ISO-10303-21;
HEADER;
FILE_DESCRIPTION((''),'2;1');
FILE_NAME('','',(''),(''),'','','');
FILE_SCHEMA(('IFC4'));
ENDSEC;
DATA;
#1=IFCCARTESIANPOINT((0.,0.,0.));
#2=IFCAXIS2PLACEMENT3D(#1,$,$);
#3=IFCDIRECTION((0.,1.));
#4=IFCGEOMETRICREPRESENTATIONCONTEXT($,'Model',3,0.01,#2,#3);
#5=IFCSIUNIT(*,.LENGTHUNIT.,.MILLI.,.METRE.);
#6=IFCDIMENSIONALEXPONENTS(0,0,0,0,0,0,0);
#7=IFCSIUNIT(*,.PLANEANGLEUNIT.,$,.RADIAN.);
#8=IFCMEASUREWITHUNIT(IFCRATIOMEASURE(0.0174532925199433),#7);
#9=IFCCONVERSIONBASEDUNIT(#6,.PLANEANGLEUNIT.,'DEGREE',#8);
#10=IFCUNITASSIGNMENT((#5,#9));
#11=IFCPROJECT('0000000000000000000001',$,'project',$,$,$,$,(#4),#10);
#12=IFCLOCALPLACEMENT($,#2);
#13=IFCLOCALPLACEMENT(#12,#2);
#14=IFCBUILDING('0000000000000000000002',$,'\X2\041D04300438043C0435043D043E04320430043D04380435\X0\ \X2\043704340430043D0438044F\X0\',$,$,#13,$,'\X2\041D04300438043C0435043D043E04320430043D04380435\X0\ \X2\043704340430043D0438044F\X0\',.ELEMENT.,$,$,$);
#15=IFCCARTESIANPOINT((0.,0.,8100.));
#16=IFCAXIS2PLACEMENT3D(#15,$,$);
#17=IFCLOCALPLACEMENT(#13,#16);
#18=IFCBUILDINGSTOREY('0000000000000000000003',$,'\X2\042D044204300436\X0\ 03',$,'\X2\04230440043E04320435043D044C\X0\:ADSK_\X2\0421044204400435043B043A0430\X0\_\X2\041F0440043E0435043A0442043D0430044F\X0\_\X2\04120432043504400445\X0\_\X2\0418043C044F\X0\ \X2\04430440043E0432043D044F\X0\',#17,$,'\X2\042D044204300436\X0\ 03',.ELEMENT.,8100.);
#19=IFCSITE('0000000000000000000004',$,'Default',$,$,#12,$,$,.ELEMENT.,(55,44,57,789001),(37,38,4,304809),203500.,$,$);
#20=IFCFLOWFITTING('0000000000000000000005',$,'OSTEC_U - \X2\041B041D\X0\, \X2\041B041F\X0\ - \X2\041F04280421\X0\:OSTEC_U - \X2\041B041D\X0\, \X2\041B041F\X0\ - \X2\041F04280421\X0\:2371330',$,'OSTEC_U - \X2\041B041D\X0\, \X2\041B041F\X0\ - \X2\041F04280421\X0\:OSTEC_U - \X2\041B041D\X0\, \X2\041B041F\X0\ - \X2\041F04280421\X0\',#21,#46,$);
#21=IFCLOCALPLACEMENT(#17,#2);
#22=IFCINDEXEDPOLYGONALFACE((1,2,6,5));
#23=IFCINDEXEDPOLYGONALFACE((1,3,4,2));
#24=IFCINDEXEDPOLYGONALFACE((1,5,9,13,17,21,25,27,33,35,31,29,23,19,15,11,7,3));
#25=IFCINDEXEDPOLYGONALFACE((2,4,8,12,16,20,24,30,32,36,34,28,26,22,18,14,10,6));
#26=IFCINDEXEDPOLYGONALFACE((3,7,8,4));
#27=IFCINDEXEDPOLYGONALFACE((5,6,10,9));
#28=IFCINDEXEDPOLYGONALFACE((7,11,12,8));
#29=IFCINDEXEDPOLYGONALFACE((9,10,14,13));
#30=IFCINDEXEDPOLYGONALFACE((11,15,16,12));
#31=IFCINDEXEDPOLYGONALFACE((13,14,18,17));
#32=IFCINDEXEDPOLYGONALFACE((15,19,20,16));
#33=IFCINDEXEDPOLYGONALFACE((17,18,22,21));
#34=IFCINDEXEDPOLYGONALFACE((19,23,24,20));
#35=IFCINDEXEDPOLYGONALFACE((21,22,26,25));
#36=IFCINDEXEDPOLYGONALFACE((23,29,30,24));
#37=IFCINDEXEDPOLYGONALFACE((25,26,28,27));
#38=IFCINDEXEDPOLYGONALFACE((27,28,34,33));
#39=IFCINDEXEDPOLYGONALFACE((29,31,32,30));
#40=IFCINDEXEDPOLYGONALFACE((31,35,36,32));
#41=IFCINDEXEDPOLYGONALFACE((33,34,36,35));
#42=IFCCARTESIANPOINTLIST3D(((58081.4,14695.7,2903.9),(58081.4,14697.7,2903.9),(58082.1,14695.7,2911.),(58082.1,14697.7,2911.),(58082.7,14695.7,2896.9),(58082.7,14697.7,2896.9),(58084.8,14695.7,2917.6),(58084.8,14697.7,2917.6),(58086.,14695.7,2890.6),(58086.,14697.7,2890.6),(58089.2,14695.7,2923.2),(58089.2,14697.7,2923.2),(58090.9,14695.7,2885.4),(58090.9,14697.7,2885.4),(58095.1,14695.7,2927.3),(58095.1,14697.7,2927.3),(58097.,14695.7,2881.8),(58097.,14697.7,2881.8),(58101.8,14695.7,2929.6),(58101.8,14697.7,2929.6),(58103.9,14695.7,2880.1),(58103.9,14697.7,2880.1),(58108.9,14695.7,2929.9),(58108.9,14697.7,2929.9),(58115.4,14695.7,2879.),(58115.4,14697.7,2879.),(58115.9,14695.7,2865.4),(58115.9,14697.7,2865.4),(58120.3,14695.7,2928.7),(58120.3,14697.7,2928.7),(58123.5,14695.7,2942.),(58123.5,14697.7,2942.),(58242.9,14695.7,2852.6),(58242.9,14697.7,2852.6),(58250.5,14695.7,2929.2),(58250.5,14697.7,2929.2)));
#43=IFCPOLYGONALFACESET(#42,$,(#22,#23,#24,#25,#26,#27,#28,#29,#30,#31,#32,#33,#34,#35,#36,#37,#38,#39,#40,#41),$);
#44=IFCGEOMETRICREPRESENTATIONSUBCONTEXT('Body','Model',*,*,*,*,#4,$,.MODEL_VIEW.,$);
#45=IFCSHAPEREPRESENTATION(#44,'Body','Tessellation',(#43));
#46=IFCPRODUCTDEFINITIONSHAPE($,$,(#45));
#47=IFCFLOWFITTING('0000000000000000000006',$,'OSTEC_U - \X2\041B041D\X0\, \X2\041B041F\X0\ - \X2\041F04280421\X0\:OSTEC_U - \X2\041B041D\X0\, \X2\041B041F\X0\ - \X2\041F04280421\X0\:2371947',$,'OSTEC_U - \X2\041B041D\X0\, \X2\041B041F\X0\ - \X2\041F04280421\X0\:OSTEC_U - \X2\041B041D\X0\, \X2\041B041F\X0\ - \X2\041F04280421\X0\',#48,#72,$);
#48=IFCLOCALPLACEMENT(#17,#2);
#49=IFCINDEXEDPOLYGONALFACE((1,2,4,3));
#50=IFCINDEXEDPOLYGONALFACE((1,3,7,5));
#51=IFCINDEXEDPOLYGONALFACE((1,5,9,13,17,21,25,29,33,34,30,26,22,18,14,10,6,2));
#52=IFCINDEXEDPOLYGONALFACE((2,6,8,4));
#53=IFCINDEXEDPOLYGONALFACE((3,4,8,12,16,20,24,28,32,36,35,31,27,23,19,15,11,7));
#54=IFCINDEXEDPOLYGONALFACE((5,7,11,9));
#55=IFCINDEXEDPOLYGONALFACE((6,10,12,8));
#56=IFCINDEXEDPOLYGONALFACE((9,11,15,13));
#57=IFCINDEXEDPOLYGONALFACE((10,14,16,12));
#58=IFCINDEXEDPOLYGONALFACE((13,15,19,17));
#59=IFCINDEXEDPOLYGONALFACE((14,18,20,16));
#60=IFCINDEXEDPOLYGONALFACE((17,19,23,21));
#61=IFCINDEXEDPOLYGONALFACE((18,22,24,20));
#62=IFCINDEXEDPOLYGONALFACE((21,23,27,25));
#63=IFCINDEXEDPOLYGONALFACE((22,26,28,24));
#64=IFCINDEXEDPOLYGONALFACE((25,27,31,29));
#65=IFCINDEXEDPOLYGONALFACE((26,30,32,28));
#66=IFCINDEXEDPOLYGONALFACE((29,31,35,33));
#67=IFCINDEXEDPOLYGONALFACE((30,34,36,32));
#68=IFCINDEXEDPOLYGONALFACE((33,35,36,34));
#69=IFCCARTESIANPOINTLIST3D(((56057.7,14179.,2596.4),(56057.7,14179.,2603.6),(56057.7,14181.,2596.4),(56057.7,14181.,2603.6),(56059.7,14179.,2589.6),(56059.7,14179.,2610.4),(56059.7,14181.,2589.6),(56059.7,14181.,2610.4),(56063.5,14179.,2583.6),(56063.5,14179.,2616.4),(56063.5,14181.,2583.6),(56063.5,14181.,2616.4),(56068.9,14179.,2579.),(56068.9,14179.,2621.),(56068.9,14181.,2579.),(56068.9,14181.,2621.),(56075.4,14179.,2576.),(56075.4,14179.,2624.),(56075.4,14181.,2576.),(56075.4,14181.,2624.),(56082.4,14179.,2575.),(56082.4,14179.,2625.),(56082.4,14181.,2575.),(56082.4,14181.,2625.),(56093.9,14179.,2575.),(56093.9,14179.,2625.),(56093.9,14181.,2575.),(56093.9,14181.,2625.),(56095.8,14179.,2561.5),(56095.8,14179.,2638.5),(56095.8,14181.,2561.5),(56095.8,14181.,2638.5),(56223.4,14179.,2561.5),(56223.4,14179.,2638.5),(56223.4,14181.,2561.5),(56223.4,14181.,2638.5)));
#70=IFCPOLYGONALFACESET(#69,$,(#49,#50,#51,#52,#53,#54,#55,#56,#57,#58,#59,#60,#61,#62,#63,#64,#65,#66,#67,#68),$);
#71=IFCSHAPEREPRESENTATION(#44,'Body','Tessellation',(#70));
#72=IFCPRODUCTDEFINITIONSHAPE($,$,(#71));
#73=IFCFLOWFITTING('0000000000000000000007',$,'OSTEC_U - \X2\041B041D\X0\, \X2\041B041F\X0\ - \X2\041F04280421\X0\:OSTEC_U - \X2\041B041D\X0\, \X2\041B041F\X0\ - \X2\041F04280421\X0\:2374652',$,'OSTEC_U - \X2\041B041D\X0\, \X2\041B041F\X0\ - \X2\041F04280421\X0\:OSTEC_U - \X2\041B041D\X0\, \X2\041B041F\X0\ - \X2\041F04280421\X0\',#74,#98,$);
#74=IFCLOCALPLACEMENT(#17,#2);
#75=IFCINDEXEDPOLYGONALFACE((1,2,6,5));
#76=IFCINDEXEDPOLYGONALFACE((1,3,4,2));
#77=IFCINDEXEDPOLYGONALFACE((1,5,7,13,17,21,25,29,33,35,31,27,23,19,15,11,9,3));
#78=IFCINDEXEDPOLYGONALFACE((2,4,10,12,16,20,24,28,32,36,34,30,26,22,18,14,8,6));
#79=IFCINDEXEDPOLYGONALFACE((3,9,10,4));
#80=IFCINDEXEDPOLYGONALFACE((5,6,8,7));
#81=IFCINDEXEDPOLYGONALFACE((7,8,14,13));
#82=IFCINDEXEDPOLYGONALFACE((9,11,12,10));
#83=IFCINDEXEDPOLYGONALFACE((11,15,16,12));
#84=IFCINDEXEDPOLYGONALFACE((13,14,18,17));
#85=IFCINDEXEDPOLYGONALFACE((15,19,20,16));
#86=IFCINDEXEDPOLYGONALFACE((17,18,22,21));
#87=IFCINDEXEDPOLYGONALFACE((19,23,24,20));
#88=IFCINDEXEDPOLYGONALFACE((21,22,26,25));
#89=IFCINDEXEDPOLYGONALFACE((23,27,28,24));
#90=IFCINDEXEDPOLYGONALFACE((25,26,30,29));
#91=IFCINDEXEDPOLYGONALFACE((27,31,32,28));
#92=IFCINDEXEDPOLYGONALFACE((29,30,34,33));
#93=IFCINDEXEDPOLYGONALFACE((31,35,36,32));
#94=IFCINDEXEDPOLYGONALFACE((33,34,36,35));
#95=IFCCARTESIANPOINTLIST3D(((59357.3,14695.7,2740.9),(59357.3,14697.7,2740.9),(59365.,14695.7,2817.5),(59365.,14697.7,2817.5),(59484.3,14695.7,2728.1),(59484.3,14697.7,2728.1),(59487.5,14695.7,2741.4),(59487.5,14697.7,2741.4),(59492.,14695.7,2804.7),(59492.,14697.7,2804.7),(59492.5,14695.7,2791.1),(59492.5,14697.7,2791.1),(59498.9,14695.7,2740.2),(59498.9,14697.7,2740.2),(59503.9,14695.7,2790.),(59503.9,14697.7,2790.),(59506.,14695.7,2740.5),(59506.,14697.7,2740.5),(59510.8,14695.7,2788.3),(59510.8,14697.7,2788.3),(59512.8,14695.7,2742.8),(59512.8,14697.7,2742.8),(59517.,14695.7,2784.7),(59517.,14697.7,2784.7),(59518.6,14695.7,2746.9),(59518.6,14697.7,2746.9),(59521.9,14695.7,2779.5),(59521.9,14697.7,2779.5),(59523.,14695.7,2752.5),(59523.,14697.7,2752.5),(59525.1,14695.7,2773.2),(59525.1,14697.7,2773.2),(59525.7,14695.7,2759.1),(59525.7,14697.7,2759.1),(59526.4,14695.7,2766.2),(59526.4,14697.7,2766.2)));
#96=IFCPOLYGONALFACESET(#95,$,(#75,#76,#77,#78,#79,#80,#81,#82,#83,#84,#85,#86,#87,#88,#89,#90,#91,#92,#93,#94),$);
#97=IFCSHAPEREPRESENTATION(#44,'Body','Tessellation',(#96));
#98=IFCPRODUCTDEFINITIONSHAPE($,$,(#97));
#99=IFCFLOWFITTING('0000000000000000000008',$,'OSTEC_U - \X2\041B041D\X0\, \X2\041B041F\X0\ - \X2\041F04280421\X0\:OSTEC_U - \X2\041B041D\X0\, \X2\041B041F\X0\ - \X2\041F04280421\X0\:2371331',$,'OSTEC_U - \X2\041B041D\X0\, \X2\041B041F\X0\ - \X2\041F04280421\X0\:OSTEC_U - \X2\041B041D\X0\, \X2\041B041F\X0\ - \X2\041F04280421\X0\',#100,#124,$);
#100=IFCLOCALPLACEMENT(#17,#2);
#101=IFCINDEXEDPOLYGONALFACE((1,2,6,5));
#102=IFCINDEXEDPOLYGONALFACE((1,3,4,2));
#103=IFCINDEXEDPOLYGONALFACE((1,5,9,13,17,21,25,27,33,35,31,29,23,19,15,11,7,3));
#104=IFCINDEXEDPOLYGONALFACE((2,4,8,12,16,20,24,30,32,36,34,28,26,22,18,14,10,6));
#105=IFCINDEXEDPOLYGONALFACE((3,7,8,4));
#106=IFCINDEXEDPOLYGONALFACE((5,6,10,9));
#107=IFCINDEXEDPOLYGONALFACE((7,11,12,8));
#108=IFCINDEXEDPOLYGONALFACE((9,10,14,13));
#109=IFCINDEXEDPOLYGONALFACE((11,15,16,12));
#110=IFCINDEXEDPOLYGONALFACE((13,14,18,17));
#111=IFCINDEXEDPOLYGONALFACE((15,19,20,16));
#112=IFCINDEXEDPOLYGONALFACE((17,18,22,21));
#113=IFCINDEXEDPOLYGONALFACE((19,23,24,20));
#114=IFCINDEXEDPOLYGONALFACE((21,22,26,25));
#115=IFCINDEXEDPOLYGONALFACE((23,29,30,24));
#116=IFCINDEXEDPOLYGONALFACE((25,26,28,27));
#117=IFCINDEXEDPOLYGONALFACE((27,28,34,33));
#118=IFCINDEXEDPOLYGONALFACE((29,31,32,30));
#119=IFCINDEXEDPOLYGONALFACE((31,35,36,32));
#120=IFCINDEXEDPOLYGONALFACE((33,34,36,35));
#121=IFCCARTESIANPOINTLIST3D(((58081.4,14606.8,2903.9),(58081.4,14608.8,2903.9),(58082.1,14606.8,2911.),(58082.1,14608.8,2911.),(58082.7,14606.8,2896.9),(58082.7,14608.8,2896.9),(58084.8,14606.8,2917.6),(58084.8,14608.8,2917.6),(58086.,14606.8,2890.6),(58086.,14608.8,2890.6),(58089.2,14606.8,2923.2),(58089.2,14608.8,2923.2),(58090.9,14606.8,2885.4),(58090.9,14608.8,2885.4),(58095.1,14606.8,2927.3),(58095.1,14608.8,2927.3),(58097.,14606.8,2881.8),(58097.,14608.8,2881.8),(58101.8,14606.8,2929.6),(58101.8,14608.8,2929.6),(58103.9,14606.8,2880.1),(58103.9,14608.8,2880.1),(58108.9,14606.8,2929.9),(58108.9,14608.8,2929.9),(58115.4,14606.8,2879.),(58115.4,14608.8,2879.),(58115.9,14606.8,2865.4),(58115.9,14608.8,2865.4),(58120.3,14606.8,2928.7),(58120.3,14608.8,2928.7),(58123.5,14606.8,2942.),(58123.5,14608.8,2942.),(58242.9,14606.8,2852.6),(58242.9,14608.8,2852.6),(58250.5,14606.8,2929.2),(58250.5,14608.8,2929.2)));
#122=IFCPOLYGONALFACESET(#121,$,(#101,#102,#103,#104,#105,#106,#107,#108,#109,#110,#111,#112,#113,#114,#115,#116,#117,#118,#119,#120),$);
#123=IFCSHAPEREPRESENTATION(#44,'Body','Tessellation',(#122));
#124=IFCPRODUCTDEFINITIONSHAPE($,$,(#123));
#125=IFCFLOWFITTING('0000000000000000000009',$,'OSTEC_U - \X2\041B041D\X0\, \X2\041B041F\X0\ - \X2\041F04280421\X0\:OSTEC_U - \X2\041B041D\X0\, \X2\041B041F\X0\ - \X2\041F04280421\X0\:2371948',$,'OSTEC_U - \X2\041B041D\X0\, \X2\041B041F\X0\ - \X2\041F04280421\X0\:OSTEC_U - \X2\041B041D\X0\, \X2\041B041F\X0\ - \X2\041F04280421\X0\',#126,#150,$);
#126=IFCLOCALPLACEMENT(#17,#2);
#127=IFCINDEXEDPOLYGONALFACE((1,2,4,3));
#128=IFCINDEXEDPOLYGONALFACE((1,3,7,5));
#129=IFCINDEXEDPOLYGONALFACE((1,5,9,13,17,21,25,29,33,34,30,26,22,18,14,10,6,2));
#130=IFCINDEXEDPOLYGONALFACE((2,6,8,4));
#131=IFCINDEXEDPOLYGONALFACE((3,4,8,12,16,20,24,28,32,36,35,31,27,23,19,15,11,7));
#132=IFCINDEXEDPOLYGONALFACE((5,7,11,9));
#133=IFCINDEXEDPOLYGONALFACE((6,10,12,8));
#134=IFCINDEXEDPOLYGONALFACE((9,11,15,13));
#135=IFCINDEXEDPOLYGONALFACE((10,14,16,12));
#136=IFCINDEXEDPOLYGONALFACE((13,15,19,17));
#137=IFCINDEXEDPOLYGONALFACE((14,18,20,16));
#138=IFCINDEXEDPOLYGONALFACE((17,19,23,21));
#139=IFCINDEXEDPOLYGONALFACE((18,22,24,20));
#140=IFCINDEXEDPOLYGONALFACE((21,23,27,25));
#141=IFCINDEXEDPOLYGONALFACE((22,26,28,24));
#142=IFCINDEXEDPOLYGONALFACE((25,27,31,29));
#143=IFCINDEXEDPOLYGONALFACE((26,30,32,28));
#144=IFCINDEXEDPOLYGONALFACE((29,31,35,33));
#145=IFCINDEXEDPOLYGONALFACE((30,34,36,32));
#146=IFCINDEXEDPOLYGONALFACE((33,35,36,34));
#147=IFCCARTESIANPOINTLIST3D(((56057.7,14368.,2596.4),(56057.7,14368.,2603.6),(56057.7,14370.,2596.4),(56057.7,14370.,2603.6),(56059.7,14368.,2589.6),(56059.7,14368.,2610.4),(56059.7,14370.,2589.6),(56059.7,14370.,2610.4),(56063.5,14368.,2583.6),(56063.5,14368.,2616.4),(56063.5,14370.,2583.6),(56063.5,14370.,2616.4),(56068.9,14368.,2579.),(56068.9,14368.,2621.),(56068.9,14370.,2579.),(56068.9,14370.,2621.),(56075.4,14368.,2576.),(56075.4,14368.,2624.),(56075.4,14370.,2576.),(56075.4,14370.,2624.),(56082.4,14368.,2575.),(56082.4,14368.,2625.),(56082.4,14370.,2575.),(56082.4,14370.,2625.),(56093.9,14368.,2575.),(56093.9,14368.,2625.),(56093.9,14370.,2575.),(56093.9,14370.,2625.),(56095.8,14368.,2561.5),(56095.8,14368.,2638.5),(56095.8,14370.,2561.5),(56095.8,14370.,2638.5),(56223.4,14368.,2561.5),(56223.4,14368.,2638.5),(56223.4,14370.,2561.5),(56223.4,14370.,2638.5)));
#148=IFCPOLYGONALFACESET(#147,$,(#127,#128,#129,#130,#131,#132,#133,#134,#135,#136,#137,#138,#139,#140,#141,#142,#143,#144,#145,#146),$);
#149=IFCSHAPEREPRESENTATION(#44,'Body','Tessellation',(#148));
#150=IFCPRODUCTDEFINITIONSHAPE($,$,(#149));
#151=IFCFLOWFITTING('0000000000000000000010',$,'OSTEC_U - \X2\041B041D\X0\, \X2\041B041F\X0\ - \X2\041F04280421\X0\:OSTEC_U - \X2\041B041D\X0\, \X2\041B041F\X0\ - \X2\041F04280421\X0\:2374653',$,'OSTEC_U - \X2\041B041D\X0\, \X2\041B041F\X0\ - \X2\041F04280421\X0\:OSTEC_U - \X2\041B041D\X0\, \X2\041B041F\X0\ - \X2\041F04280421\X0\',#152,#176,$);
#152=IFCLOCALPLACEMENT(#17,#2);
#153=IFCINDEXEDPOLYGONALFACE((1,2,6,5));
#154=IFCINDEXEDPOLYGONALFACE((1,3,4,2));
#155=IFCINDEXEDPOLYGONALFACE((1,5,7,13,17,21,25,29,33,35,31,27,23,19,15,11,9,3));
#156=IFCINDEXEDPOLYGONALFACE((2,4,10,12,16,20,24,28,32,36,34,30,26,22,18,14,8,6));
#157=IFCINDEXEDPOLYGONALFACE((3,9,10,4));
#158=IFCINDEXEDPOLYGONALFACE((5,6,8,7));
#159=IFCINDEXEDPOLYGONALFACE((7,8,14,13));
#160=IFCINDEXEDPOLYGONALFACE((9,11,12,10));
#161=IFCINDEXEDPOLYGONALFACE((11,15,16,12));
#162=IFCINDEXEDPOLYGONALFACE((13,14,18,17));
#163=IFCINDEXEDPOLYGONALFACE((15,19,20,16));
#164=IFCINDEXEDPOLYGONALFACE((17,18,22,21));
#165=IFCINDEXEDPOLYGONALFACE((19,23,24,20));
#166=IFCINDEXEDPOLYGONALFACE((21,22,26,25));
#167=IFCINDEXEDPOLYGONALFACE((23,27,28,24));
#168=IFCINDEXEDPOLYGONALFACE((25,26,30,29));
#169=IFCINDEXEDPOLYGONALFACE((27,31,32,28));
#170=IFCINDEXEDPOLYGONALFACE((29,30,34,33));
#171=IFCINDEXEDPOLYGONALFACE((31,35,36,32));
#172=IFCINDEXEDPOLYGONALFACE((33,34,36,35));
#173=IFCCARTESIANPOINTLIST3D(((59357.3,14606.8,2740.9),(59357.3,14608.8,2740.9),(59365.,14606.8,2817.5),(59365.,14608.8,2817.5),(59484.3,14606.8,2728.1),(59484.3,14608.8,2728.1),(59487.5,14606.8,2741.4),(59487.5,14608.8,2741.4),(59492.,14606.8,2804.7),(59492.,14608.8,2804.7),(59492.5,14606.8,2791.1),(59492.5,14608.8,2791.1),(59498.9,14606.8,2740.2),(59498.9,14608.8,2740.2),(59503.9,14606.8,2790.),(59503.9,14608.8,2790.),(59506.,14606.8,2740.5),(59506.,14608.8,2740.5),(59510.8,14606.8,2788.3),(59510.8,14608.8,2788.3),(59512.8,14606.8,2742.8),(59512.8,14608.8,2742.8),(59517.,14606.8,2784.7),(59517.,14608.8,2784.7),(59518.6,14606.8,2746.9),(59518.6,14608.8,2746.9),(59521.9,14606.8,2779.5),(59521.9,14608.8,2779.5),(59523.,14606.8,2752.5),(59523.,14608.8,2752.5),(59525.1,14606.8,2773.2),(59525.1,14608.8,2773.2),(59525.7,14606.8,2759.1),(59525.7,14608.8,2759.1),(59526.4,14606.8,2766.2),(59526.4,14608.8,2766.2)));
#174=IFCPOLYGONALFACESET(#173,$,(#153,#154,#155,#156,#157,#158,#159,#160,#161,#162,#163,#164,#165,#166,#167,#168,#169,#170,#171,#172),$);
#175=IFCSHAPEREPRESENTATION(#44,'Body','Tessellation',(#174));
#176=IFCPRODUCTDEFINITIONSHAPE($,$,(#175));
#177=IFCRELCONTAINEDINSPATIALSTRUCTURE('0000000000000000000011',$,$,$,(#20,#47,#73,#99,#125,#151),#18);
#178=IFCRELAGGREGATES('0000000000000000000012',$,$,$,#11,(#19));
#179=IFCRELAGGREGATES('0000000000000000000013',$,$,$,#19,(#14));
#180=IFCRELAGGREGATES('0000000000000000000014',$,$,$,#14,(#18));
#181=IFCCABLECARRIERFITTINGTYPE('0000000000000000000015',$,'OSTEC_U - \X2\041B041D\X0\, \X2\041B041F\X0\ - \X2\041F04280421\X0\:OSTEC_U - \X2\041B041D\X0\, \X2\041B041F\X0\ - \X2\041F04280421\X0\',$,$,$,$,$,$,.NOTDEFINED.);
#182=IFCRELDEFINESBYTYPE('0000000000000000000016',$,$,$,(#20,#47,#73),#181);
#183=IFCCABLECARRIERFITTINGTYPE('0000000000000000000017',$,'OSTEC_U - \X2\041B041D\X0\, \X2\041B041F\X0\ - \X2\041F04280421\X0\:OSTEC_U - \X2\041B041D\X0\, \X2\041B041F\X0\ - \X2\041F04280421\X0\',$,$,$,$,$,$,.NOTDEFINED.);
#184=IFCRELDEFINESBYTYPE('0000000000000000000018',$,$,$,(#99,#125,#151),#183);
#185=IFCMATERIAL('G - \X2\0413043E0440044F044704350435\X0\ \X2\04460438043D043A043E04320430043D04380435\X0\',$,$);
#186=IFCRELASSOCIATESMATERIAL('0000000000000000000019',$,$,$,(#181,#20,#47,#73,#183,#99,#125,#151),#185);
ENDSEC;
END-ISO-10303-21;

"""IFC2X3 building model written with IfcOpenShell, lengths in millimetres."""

from ifc_helpers import new_model, entity, si_unit, converted_unit, direction, frame, frame_2d, origin, place, context, subcontext, project, spatial, polyline, circle_curve, parameter, trimmed, segment, composite_curve, outline, extrude, source, transform, mapped, material, type_object, type_shapes, element, save


model = new_model("IFC2X3")

# Units and contexts
model_context = context("Model", 3, precision=0.01, world=origin(), true_north=direction((0.0, 1.0)))
body_context = subcontext(model_context, "Body", "Model", "MODEL_VIEW")
ifc_project = project(units=[si_unit("LENGTHUNIT", "METRE", prefix="MILLI"), converted_unit("PLANEANGLEUNIT", "DEGREE", entity("IfcRatioMeasure", 0.0174532925199433), si_unit("PLANEANGLEUNIT", "RADIAN"), dimensions=[0, 0, 0, 0, 0, 0, 0])], contexts=[model_context])

# Site, building, storey
site_placement = place(None, frame((0.0, 0.0, 0.0)))
site = spatial("IfcSite", under=ifc_project, at=site_placement, Name="Default", CompositionType="ELEMENT", RefLatitude=(55, 44, 57, 789001), RefLongitude=(37, 38, 4, 304809), RefElevation=203500.0)
building_placement = place(site_placement, origin())
building = spatial("IfcBuilding", under=site, at=building_placement, Name="Наименование здания", LongName="Наименование здания", CompositionType="ELEMENT")
storey_placement = place(building_placement, frame((0.0, 0.0, 8100.0)))
storey = spatial("IfcBuildingStorey", under=building, at=storey_placement, Name="Этаж 03", ObjectType="Уровень:ADSK_Стрелка_Проектная_Вверх_Имя уровня", LongName="Этаж 03", CompositionType="ELEMENT", Elevation=8100.0)

# Flow fittings
ifc_material = material(Name="G - Горячее цинкование")
cable_carrier_fitting_type_1 = type_object("IfcCableCarrierFittingType", Name="OSTEC_U - ЛН, ЛП - ПШС:OSTEC_U - ЛН, ЛП - ПШС", PredefinedType="NOTDEFINED", material=ifc_material)
shared_shape_1 = source(origin(), body_context, "Body", "SweptSolid", [
    extrude(outline(composite_curve([segment(trimmed(circle_curve(frame_2d((-41.5, 0.0), x_axis=(1.0, 0.0)), 25.0), [parameter(90.0)], [parameter(270.0)], True, "PARAMETER"), True, "CONTINUOUS"), segment(polyline([(-41.5, -25.0), (-30.0, -25.0)]), True, "CONTINUOUS"), segment(polyline([(-30.0, -25.0), (-28.1, -38.5)]), True, "CONTINUOUS"), segment(polyline([(-28.1, -38.5), (99.5, -38.5)]), True, "CONTINUOUS"), segment(polyline([(99.5, -38.5), (99.5, 38.5)]), True, "CONTINUOUS"), segment(polyline([(99.5, 38.5), (-28.1, 38.5)]), True, "CONTINUOUS"), segment(polyline([(-28.1, 38.5), (-30.0, 25.0)]), True, "CONTINUOUS"), segment(polyline([(-30.0, 25.0), (-41.5, 25.0)]), True, "CONTINUOUS")], self_intersect=False)), frame((41.5, 0.0, 0.0), z_axis=(0.0, 0.0, -1.0), x_axis=(1.0, 0.0, 0.0)), (0.0, 0.0, -1.0), 2.0),
])
type_shapes(cable_carrier_fitting_type_1, [shared_shape_1])
for number, where, z_axis, x_axis, name in (
    (1, (58106.4, 14695.7, 2905.0), (0.0, 1.0, 0.0), (0.995009, 0.0, -0.099785), "OSTEC_U - ЛН, ЛП - ПШС:OSTEC_U - ЛН, ЛП - ПШС:2371330"),
    (2, (56082.4, 14181.0, 2600.0), (0.0, -1.0, 0.0), (1.0, 0.0, 0.0), "OSTEC_U - ЛН, ЛП - ПШС:OSTEC_U - ЛН, ЛП - ПШС:2371947"),
    (3, (59501.4, 14695.7, 2765.1), (0.0, 1.0, 0.0), (-0.995009, 0.0, 0.099785), "OSTEC_U - ЛН, ЛП - ПШС:OSTEC_U - ЛН, ЛП - ПШС:2374652"),
):
    element("IfcFlowFitting", number, at=place(storey_placement, frame(where, z_axis=z_axis, x_axis=x_axis)), inside=storey, type_object=cable_carrier_fitting_type_1, material=ifc_material, Name=name, ObjectType="OSTEC_U - ЛН, ЛП - ПШС:OSTEC_U - ЛН, ЛП - ПШС", context=body_context, shape_type="MappedRepresentation", body=[
        mapped(shared_shape_1, transform((0.0, 0.0, 0.0), scale=1.0)),
    ])
cable_carrier_fitting_type_2 = type_object("IfcCableCarrierFittingType", Name="OSTEC_U - ЛН, ЛП - ПШС:OSTEC_U - ЛН, ЛП - ПШС", PredefinedType="NOTDEFINED", material=ifc_material)
shared_shape_2 = source(origin(), body_context, "Body", "SweptSolid", [
    extrude(outline(composite_curve([segment(trimmed(circle_curve(frame_2d((-41.5, 0.0), x_axis=(1.0, 0.0)), 25.0), [parameter(90.0)], [parameter(270.0)], True, "PARAMETER"), True, "CONTINUOUS"), segment(polyline([(-41.5, -25.0), (-30.0, -25.0)]), True, "CONTINUOUS"), segment(polyline([(-30.0, -25.0), (-28.1, -38.5)]), True, "CONTINUOUS"), segment(polyline([(-28.1, -38.5), (99.5, -38.5)]), True, "CONTINUOUS"), segment(polyline([(99.5, -38.5), (99.5, 38.5)]), True, "CONTINUOUS"), segment(polyline([(99.5, 38.5), (-28.1, 38.5)]), True, "CONTINUOUS"), segment(polyline([(-28.1, 38.5), (-30.0, 25.0)]), True, "CONTINUOUS"), segment(polyline([(-30.0, 25.0), (-41.5, 25.0)]), True, "CONTINUOUS")], self_intersect=False)), frame((41.5, 0.0, 0.0)), (0.0, 0.0, 1.0), 2.0),
])
type_shapes(cable_carrier_fitting_type_2, [shared_shape_2])
for number, where, z_axis, x_axis, name in (
    (4, (58106.4, 14608.8, 2905.0), (0.0, -1.0, 0.0), (0.995009, 0.0, -0.099785), "OSTEC_U - ЛН, ЛП - ПШС:OSTEC_U - ЛН, ЛП - ПШС:2371331"),
    (5, (56082.4, 14368.0, 2600.0), (0.0, 1.0, 0.0), (1.0, 0.0, 0.0), "OSTEC_U - ЛН, ЛП - ПШС:OSTEC_U - ЛН, ЛП - ПШС:2371948"),
    (6, (59501.4, 14608.8, 2765.1), (0.0, -1.0, 0.0), (-0.995009, 0.0, 0.099785), "OSTEC_U - ЛН, ЛП - ПШС:OSTEC_U - ЛН, ЛП - ПШС:2374653"),
):
    element("IfcFlowFitting", number, at=place(storey_placement, frame(where, z_axis=z_axis, x_axis=x_axis)), inside=storey, type_object=cable_carrier_fitting_type_2, material=ifc_material, Name=name, ObjectType="OSTEC_U - ЛН, ЛП - ПШС:OSTEC_U - ЛН, ЛП - ПШС", context=body_context, shape_type="MappedRepresentation", body=[
        mapped(shared_shape_2, transform((0.0, 0.0, 0.0), scale=1.0)),
    ])

save(model, "model.ifc")
